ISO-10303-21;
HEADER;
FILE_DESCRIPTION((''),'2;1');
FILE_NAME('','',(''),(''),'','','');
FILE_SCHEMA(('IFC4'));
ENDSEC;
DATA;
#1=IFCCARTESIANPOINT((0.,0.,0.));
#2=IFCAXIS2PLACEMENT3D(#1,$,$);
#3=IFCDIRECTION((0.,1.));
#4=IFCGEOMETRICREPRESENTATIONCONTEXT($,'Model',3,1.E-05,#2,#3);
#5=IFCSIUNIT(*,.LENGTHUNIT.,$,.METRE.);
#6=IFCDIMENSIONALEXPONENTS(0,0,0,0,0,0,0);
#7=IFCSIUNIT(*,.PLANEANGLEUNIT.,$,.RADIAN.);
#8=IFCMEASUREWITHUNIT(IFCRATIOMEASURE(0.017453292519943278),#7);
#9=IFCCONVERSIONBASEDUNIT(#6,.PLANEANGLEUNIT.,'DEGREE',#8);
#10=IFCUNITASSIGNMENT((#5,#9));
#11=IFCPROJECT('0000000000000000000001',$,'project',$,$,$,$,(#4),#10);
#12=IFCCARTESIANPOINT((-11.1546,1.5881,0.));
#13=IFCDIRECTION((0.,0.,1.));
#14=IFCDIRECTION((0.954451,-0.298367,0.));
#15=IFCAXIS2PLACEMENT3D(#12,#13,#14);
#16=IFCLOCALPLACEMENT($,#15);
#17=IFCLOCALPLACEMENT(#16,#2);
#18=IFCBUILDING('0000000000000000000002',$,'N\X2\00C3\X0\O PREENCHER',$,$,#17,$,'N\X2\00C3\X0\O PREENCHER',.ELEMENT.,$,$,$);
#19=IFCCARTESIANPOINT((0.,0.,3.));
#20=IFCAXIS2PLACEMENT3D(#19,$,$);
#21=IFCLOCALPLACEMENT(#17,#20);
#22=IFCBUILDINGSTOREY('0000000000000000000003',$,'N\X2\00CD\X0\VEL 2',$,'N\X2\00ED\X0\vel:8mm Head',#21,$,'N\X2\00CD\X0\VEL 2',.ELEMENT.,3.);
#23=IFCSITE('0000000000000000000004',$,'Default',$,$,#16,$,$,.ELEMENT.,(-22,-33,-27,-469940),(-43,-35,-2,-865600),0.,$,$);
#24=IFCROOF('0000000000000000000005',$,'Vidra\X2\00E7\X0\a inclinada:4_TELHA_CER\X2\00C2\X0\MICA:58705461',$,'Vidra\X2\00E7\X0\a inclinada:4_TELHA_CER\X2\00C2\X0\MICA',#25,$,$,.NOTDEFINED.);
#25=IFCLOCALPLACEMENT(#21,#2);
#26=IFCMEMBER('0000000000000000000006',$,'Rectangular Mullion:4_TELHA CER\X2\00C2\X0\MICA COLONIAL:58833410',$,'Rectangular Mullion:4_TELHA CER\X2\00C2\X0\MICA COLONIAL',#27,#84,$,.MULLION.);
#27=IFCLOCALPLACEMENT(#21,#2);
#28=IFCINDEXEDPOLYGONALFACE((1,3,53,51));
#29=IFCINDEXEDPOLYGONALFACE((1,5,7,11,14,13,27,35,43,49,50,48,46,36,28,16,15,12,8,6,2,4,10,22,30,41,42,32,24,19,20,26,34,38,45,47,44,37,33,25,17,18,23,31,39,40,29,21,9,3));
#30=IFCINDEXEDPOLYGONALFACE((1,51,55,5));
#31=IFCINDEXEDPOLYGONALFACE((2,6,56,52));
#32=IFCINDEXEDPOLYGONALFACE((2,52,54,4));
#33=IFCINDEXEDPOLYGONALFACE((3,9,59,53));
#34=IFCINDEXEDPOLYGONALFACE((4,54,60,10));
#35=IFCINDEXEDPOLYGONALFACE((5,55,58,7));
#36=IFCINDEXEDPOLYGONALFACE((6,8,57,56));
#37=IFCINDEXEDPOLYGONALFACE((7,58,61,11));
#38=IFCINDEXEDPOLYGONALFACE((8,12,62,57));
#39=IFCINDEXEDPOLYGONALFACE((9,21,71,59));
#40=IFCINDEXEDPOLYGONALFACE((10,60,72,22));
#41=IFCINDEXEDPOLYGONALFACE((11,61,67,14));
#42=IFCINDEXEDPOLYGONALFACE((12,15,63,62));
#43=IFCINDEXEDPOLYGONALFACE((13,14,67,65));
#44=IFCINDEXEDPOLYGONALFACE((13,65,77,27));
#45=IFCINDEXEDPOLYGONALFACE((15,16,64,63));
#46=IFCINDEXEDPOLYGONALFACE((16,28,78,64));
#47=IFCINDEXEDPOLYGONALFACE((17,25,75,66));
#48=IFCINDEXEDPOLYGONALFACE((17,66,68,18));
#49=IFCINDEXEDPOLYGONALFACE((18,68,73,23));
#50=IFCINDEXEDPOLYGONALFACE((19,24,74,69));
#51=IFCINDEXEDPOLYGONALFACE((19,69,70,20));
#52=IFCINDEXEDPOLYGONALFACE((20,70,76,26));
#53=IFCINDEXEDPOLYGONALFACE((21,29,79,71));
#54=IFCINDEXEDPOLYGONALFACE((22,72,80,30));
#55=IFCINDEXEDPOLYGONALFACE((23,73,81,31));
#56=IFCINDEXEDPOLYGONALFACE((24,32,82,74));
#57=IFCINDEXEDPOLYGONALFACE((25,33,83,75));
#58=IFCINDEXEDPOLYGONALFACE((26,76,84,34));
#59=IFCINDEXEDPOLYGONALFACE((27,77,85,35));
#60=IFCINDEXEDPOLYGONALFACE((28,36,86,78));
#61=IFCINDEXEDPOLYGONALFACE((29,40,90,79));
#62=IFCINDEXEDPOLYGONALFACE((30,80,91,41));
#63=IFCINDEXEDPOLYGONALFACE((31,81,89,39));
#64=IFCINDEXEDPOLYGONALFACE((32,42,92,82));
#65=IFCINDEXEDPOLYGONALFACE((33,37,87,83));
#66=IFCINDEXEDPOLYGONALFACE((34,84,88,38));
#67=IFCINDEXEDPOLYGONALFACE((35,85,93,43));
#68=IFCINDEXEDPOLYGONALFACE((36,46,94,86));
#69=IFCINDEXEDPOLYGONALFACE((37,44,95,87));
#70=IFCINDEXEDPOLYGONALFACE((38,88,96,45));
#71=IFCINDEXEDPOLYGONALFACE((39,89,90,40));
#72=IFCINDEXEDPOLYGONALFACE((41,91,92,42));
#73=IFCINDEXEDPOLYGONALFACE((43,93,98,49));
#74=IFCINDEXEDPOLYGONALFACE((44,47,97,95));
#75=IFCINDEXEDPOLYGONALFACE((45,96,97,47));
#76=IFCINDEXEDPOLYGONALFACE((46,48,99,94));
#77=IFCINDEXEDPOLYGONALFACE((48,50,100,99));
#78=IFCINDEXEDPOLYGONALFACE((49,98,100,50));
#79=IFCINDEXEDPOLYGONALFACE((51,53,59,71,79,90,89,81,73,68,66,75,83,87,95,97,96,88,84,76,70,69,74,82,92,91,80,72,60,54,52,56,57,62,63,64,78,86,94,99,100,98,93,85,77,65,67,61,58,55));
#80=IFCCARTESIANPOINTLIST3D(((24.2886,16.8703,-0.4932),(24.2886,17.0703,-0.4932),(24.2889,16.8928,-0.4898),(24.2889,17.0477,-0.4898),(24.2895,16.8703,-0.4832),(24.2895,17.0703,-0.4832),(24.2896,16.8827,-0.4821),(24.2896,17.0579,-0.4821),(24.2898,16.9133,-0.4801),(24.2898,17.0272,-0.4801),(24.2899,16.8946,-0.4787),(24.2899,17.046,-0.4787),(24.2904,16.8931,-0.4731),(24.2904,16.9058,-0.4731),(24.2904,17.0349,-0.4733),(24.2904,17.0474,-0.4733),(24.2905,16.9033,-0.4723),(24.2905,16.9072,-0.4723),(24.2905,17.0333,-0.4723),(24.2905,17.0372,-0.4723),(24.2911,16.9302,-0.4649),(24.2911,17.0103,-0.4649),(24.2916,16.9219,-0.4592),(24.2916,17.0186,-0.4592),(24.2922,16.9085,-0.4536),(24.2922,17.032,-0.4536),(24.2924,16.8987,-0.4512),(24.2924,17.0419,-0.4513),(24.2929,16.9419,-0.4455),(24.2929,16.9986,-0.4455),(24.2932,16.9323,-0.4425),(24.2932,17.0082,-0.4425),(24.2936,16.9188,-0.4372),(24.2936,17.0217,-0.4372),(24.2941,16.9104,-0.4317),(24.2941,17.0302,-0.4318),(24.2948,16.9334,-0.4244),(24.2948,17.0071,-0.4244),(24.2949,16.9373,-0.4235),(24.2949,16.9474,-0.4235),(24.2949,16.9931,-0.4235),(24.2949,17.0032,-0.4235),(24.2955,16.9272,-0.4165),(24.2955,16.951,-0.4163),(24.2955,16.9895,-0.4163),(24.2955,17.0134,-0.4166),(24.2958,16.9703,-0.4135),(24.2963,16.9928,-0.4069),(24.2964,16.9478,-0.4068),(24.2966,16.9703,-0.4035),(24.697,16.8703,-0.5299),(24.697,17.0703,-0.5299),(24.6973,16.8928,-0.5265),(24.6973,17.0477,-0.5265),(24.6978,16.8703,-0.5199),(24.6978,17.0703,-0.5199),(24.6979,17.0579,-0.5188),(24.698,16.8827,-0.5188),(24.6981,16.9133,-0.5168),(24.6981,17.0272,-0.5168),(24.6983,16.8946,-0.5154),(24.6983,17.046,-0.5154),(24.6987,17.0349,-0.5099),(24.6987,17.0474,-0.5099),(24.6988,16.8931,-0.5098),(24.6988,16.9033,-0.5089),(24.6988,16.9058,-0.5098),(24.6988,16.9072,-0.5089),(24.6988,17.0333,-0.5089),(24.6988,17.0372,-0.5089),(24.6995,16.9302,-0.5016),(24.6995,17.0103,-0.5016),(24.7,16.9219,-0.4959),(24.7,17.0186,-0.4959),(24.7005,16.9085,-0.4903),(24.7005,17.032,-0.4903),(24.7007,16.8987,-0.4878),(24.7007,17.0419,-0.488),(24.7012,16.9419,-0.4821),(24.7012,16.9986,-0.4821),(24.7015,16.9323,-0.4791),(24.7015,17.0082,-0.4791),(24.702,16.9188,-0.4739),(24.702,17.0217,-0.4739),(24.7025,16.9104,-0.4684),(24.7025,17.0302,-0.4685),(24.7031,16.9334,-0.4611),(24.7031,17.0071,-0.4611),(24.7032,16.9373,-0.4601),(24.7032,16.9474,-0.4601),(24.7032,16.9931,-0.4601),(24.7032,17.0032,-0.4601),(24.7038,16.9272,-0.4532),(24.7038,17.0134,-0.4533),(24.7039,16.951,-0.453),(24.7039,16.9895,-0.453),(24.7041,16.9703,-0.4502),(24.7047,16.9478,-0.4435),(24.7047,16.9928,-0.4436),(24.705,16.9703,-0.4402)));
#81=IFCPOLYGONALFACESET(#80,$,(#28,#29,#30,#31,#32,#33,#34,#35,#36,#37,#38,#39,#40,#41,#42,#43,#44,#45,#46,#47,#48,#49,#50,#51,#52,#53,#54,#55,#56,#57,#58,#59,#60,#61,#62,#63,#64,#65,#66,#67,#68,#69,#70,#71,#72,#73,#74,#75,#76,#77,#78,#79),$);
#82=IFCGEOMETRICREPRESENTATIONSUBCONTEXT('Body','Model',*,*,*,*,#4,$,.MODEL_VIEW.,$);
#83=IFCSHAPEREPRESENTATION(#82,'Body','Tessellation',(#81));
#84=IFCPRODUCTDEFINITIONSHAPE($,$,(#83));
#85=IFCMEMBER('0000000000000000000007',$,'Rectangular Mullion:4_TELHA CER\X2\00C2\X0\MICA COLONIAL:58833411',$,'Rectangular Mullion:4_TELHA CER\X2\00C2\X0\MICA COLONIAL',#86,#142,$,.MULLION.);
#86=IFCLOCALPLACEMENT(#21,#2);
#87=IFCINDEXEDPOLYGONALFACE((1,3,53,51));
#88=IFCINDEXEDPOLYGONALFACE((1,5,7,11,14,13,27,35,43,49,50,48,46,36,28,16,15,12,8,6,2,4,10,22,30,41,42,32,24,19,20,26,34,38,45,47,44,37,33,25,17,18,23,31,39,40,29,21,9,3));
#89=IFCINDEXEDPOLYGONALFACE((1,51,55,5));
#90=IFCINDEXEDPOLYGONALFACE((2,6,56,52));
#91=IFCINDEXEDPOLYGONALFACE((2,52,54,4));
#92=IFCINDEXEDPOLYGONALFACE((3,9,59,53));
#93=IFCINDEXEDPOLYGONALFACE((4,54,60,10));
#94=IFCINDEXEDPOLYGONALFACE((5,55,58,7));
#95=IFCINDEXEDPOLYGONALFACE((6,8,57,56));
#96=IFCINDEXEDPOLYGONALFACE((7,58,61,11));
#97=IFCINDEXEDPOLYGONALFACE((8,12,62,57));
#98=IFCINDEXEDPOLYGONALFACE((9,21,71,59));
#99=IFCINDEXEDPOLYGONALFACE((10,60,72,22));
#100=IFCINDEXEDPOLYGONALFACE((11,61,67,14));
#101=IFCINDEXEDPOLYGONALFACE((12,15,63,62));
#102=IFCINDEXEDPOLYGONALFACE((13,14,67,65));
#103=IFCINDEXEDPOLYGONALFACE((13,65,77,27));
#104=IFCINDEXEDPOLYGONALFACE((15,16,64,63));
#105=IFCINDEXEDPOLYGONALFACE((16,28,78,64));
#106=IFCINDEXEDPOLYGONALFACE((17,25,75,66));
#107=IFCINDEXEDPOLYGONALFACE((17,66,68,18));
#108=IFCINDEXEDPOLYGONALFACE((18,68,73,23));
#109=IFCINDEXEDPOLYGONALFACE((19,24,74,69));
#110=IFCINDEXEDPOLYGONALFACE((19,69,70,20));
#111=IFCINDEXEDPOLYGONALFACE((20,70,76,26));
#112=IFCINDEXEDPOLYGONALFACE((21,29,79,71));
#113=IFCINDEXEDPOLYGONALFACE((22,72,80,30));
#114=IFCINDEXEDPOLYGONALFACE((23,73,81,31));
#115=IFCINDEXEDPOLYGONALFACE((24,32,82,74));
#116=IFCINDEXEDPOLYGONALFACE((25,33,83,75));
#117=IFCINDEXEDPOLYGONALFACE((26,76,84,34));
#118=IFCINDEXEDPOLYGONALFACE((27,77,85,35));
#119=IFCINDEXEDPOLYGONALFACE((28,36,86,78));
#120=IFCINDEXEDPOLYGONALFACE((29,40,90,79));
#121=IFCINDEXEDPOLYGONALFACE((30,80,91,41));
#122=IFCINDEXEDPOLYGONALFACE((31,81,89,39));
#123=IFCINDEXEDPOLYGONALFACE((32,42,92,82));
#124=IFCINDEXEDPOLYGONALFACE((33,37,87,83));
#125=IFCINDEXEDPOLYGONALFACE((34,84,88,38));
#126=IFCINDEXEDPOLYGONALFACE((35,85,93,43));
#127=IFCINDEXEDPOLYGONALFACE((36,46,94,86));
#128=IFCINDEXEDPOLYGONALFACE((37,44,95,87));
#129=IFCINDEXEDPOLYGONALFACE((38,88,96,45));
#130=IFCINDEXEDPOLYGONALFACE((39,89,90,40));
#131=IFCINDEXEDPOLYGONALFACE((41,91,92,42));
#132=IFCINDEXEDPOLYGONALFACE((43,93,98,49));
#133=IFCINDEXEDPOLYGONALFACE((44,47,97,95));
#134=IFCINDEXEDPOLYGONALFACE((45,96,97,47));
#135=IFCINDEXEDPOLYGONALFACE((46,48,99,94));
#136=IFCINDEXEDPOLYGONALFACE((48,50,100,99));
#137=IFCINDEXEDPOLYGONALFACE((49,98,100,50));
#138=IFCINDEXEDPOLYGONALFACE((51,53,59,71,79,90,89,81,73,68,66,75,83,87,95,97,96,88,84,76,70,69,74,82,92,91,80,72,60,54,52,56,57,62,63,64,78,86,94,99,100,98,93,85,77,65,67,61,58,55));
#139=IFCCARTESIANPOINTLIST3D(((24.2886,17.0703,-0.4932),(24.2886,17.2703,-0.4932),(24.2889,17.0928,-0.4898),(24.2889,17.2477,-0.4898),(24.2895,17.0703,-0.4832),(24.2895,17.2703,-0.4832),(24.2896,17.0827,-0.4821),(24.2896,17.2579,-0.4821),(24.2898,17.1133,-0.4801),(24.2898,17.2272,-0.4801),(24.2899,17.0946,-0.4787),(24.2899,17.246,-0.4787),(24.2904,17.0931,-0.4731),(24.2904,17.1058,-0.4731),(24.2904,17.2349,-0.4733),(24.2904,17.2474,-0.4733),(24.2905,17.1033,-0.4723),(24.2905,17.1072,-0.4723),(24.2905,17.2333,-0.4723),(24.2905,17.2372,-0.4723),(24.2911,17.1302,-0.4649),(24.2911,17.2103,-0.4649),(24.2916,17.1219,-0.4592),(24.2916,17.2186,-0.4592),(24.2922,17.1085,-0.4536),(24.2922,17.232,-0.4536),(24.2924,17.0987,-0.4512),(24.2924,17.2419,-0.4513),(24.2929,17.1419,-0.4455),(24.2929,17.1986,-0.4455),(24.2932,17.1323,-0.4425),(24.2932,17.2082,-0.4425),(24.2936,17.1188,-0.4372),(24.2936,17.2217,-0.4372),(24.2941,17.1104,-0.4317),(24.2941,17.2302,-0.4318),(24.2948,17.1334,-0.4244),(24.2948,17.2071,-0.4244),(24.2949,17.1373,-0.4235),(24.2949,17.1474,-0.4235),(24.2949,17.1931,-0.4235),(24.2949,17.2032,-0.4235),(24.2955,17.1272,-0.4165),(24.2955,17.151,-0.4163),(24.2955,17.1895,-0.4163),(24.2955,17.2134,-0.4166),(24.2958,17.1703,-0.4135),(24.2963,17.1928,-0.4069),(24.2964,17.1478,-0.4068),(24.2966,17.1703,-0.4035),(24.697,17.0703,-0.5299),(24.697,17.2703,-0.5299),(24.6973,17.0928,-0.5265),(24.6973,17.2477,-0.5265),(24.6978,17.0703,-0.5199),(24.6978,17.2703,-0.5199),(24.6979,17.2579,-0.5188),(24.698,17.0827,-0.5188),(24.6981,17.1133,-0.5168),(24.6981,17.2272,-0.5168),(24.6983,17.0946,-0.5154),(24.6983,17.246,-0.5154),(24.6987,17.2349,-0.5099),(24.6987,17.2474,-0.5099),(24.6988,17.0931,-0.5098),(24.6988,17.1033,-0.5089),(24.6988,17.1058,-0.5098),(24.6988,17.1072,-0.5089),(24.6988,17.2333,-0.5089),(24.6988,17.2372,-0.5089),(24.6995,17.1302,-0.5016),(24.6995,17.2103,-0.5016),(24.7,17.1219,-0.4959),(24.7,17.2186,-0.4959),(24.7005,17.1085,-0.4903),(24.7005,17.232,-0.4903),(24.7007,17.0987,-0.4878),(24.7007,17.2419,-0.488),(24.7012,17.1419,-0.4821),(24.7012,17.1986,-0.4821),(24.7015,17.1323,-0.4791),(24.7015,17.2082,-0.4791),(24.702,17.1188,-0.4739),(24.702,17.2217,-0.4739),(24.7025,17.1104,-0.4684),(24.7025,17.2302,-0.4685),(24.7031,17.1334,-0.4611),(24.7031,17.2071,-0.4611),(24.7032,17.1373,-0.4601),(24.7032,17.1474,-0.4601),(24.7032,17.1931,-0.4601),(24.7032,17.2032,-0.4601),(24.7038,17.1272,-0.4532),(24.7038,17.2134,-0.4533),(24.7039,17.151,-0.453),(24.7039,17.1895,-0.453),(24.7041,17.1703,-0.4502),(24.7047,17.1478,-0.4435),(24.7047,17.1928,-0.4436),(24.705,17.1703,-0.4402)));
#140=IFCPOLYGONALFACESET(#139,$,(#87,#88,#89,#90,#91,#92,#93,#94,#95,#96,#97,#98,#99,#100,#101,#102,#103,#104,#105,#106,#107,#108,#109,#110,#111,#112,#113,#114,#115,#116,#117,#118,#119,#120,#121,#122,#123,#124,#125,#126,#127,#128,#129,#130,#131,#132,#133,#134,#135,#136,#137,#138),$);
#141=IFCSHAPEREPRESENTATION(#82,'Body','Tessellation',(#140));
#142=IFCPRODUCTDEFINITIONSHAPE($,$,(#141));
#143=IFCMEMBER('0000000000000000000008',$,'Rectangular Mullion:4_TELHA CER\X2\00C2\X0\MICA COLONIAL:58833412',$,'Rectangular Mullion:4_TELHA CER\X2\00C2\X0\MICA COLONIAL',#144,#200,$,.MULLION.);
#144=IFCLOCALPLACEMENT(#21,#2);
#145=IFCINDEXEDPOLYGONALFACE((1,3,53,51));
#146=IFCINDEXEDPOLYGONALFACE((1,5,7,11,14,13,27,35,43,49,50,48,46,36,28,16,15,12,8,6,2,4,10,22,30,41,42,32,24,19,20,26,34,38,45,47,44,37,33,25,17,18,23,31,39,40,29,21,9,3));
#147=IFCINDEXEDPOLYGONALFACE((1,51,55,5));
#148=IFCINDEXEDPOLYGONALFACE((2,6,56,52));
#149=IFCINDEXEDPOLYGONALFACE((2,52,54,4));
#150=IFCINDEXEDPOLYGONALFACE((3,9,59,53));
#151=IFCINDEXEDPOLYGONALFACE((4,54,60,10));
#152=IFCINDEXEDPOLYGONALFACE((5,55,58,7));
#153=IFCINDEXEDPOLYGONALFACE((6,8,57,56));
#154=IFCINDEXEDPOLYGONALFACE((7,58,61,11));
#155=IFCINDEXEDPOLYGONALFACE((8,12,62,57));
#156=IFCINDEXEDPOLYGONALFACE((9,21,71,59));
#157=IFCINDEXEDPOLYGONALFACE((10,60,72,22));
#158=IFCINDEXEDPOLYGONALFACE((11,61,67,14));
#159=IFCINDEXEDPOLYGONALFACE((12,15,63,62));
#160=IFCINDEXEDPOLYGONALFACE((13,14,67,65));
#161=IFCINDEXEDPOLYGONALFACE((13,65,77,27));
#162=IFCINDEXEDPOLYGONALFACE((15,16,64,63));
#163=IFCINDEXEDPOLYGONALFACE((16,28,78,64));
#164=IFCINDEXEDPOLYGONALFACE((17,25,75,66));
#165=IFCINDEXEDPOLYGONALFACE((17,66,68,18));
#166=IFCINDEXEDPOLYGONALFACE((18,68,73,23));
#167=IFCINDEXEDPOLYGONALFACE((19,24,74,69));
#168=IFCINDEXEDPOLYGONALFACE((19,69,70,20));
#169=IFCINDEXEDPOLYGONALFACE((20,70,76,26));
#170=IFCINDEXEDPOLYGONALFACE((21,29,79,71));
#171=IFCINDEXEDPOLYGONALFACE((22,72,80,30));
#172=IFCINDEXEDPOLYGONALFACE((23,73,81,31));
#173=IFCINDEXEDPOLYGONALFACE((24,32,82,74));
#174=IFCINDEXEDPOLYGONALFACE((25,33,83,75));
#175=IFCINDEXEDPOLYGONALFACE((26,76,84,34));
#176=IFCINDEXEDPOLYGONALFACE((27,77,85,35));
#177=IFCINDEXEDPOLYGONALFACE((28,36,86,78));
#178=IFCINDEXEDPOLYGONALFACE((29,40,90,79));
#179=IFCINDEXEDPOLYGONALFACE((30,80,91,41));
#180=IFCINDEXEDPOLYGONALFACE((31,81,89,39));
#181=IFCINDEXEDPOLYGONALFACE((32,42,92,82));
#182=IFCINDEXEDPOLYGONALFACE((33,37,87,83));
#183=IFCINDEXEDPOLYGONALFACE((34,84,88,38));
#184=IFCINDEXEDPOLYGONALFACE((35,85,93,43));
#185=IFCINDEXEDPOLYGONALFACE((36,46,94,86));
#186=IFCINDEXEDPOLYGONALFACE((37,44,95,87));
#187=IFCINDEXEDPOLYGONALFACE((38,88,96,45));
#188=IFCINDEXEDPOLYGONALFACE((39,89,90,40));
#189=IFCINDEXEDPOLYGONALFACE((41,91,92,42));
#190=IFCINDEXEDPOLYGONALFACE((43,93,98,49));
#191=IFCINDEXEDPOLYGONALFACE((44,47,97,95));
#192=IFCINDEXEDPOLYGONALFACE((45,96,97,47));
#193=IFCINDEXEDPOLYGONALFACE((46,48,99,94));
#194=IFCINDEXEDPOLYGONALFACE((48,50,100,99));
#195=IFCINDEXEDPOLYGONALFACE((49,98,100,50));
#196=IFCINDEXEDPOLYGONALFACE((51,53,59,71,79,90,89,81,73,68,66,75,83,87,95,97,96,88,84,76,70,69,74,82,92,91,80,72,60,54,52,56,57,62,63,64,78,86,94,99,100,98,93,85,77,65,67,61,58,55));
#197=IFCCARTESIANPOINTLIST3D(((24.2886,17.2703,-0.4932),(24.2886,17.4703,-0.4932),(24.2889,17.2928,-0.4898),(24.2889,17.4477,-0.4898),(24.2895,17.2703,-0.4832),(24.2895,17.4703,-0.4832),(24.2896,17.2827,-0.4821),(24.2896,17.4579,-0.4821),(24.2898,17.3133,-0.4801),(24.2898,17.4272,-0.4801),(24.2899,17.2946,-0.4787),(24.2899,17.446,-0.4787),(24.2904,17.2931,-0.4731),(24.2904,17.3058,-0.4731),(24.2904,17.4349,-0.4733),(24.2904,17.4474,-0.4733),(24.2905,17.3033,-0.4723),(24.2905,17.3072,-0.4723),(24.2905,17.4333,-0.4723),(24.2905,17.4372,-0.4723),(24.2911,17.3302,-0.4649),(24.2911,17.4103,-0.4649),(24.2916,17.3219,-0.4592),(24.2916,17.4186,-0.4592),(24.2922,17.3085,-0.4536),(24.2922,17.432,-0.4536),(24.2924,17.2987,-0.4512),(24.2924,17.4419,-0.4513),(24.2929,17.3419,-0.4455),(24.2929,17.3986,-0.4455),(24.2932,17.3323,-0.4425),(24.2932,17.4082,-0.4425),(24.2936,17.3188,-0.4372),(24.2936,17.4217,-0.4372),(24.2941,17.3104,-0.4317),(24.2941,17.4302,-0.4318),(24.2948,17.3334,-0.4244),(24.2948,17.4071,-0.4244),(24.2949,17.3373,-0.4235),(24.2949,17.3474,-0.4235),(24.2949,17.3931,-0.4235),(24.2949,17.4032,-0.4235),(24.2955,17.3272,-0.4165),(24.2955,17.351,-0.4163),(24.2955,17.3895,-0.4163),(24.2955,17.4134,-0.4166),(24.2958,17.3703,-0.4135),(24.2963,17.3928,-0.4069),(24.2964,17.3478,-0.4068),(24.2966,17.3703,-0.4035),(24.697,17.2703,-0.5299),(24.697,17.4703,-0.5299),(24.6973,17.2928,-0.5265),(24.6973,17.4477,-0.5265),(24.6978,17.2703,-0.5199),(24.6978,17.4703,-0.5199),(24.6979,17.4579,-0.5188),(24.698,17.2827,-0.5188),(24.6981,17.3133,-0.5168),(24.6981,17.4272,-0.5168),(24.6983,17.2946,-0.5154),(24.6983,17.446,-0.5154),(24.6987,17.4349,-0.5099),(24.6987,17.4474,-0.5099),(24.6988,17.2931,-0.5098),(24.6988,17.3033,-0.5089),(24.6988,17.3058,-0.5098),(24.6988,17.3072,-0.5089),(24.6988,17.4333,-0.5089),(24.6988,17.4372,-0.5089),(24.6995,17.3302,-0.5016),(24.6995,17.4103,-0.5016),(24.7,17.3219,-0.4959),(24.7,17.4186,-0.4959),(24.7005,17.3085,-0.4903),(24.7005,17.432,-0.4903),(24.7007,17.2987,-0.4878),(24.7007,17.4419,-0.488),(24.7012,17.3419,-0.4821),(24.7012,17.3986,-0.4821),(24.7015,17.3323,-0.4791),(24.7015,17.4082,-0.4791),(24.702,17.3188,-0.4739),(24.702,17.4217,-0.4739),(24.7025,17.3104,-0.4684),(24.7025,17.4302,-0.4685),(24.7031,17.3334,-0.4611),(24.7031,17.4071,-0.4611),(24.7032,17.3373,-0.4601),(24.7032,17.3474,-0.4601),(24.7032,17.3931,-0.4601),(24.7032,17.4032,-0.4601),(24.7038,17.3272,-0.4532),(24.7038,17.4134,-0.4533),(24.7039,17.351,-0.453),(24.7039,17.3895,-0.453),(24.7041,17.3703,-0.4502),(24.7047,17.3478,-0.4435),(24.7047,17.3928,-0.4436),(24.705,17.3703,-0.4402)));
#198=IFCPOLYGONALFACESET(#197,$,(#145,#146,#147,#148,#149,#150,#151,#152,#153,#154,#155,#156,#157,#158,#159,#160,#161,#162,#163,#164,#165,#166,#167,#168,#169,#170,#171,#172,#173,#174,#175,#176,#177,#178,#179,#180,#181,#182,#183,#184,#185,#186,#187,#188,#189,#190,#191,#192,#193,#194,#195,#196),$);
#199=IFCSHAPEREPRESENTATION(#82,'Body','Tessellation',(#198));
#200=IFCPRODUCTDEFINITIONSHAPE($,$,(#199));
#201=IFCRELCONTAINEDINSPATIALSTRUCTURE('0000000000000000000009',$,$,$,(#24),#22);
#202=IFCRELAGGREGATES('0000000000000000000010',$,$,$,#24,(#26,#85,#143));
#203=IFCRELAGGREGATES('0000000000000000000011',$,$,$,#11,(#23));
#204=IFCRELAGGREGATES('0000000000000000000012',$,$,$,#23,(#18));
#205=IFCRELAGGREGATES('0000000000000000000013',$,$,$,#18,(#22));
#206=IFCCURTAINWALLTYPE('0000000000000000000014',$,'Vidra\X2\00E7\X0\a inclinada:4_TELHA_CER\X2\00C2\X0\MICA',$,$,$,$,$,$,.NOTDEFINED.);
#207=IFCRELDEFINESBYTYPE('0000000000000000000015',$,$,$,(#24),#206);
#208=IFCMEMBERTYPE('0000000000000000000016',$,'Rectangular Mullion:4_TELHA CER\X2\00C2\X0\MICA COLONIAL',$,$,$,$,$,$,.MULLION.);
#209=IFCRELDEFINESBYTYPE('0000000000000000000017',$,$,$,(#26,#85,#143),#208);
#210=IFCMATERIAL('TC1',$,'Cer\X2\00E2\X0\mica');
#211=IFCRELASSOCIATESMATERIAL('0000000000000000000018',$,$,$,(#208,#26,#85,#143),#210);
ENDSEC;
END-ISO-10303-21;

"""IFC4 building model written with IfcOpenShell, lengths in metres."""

from ifc_helpers import new_model, entity, si_unit, converted_unit, direction, frame, origin, place, context, subcontext, project, spatial, line, arc, indexed_curve, outline, extrude, source, transform, mapped, material, type_object, type_shapes, element, aggregate, save


model = new_model("IFC4")

# Units and contexts
model_context = context("Model", 3, precision=1e-05, world=origin(), true_north=direction((0.0, 1.0)))
body_context = subcontext(model_context, "Body", "Model", "MODEL_VIEW")
ifc_project = project(units=[si_unit("LENGTHUNIT", "METRE"), converted_unit("PLANEANGLEUNIT", "DEGREE", entity("IfcRatioMeasure", 0.017453292519943278), si_unit("PLANEANGLEUNIT", "RADIAN"), dimensions=[0, 0, 0, 0, 0, 0, 0])], contexts=[model_context])

# Site, building, storey
site_placement = place(None, frame((-11.1546, 1.5881, 0.0), z_axis=(0.0, 0.0, 1.0), x_axis=(0.954451, -0.298367, 0.0)))
site = spatial("IfcSite", under=ifc_project, at=site_placement, Name="Default", CompositionType="ELEMENT", RefLatitude=(-22, -33, -27, -469940), RefLongitude=(-43, -35, -2, -865600), RefElevation=0.0)
building_placement = place(site_placement, origin())
building = spatial("IfcBuilding", under=site, at=building_placement, Name="NÃO PREENCHER", LongName="NÃO PREENCHER", CompositionType="ELEMENT")
storey_placement = place(building_placement, frame((0.0, 0.0, 3.0)))
storey = spatial("IfcBuildingStorey", under=building, at=storey_placement, Name="NÍVEL 2", ObjectType="Nível:8mm Head", LongName="NÍVEL 2", CompositionType="ELEMENT", Elevation=3.0)

# Roof, members
curtain_wall_type = type_object("IfcCurtainWallType", Name="Vidraça inclinada:4_TELHA_CERÂMICA", PredefinedType="NOTDEFINED")
roof_placement = place(storey_placement, frame((0.0, 0.0, -3.0)))
roof = element("IfcRoof", 1, at=roof_placement, inside=storey, type_object=curtain_wall_type, Name="Vidraça inclinada:4_TELHA_CERÂMICA:58705461", ObjectType="Vidraça inclinada:4_TELHA_CERÂMICA", PredefinedType="NOTDEFINED")
ifc_material_1 = material(Name="TC1", Category="Cerâmica")
member_type_1 = type_object("IfcMemberType", Name="Rectangular Mullion:4_TELHA CERÂMICA COLONIAL", PredefinedType="MULLION", material=ifc_material_1)
shared_shape_1 = source(origin(), body_context, "Body", "SweptSolid", [
    extrude(outline(indexed_curve([(-0.029, -0.1), (-0.019, -0.1), (-0.0164, -0.0815), (-0.0089, -0.0645), (-0.0089, -0.0771), (0.061, 0.0), (-0.009, 0.0771), (-0.009, 0.0646), (-0.0165, 0.0816), (-0.019, 0.1), (-0.029, 0.1), (-0.0089, 0.0479), (0.041, 0.0229), (0.041, 0.0329), (0.0131, 0.0425), (-0.008, 0.0631), (-0.008, 0.067), (0.051, 0.0), (-0.008, -0.067), (-0.008, -0.0631), (0.0131, -0.0425), (0.041, -0.0329), (0.041, -0.0229), (-0.0089, -0.0479)], segments=[line(1, 2), arc(2, 3, 4), line(4, 5), arc(5, 6, 7), line(7, 8), arc(8, 9, 10), line(10, 11), arc(11, 12, 13), line(13, 14), arc(14, 15, 16), line(16, 17), arc(17, 18, 19), line(19, 20), arc(20, 21, 22), line(22, 23), arc(23, 24, 1)], self_intersect=False)), frame((0.0, -0.029, -0.41), z_axis=(0.0, 0.0, 1.0), x_axis=(0.0, -1.0, 0.0)), (0.0, 0.0, 1.0), 0.41),
])
type_shapes(member_type_1, [shared_shape_1])
member_1_placement = place(roof_placement, frame((24.2886, 16.9703, 2.5068), z_axis=(-0.99599, 0.0, 0.089469), x_axis=(0.0, 1.0, 0.0)))
member_1 = element("IfcMember", 2, at=member_1_placement, type_object=member_type_1, material=ifc_material_1, Name="Rectangular Mullion:4_TELHA CERÂMICA COLONIAL:58833410", ObjectType="Rectangular Mullion:4_TELHA CERÂMICA COLONIAL", PredefinedType="MULLION", context=body_context, shape_type="MappedRepresentation", body=[
    mapped(shared_shape_1, transform((0.0, 0.0, 0.0), scale=1.0)),
])
member_2_placement = place(roof_placement, frame((24.2886, 17.1703, 2.5068), z_axis=(-0.99599, 0.0, 0.089469), x_axis=(0.0, 1.0, 0.0)))
member_2 = element("IfcMember", 3, at=member_2_placement, type_object=member_type_1, material=ifc_material_1, Name="Rectangular Mullion:4_TELHA CERÂMICA COLONIAL:58833411", ObjectType="Rectangular Mullion:4_TELHA CERÂMICA COLONIAL", PredefinedType="MULLION", context=body_context, shape_type="MappedRepresentation", body=[
    mapped(shared_shape_1, transform((0.0, 0.0, 0.0), scale=1.0)),
])
member_3_placement = place(roof_placement, frame((24.2886, 17.3703, 2.5068), z_axis=(-0.99599, 0.0, 0.089469), x_axis=(0.0, 1.0, 0.0)))
member_3 = element("IfcMember", 4, at=member_3_placement, type_object=member_type_1, material=ifc_material_1, Name="Rectangular Mullion:4_TELHA CERÂMICA COLONIAL:58833412", ObjectType="Rectangular Mullion:4_TELHA CERÂMICA COLONIAL", PredefinedType="MULLION", context=body_context, shape_type="MappedRepresentation", body=[
    mapped(shared_shape_1, transform((0.0, 0.0, 0.0), scale=1.0)),
])
aggregate(roof, [member_1, member_2, member_3])

save(model, "model.ifc")
